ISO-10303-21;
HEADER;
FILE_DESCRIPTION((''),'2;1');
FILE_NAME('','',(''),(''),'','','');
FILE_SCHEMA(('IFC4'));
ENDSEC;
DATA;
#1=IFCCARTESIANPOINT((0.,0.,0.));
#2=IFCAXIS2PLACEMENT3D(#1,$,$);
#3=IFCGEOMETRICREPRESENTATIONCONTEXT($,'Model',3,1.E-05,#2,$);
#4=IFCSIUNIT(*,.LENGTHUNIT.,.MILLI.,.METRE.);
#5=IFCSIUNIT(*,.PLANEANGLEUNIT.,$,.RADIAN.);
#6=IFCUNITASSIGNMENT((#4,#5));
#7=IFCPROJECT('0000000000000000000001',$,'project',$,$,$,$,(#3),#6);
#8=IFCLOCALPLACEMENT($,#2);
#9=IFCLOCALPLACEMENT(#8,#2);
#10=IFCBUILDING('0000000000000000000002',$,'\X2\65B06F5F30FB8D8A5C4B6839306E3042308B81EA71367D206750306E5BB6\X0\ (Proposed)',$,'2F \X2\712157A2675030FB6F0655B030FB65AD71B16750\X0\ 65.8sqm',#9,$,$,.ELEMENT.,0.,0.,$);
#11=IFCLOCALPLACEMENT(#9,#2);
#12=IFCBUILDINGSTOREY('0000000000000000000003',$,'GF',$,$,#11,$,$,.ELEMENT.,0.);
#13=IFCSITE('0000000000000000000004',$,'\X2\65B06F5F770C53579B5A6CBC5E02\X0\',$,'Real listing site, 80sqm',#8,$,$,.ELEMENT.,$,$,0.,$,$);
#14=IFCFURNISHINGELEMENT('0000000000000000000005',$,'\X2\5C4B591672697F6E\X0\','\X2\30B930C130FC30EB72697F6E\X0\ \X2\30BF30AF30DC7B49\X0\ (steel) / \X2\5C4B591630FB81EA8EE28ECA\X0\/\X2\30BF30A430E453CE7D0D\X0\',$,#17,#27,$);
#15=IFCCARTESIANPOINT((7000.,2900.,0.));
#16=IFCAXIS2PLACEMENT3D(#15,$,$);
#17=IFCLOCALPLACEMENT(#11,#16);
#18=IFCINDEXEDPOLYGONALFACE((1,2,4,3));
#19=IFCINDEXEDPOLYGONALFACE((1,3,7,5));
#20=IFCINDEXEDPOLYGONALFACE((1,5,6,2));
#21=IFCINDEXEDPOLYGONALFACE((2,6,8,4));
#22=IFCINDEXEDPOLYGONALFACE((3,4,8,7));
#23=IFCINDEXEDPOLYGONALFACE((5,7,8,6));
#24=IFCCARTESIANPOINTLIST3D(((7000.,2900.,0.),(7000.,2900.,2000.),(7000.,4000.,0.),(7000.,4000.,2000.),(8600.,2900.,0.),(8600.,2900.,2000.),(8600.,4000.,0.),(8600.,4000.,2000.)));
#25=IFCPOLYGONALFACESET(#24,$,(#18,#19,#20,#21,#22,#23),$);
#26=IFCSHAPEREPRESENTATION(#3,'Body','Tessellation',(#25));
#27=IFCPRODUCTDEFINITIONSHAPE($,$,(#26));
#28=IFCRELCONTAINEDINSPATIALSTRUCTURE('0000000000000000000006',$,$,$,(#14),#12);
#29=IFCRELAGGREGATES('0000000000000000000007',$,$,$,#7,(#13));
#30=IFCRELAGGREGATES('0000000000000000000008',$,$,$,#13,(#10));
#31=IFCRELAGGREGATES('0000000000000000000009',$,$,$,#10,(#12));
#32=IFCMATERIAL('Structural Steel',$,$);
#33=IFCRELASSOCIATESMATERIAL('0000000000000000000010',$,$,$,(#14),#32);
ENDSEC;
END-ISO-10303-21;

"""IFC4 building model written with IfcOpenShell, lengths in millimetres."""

from ifc_helpers import new_model, si_unit, frame, frame_2d, origin, place, context, project, spatial, rectangle, extrude, material, element, save


model = new_model("IFC4")

# Units and contexts
model_context = context("Model", 3, precision=1e-05, world=origin())
ifc_project = project(units=[si_unit("LENGTHUNIT", "METRE", prefix="MILLI"), si_unit("PLANEANGLEUNIT", "RADIAN")], contexts=[model_context])

# Site, building, storey
site_placement = place(None, origin())
site = spatial("IfcSite", under=ifc_project, at=site_placement, Name="新潟県南魚沼市", ObjectType="Real listing site, 80sqm", CompositionType="ELEMENT", RefElevation=0.0)
building_placement = place(site_placement, origin())
building = spatial("IfcBuilding", under=site, at=building_placement, Name="新潟・越屋根のある自然素材の家 (Proposed)", ObjectType="2F 無垢材・漆喰・断熱材 65.8sqm", CompositionType="ELEMENT", ElevationOfRefHeight=0.0, ElevationOfTerrain=0.0)
storey_placement = place(building_placement, origin())
storey = spatial("IfcBuildingStorey", under=building, at=storey_placement, Name="GF", CompositionType="ELEMENT", Elevation=0.0)

# Shared definitions
ifc_material_1 = material(Name="Structural Steel")

# Furnishing element
furnishing_1_placement = place(storey_placement, frame((7000.0, 2900.0, 0.0)))
element("IfcFurnishingElement", 1, at=furnishing_1_placement, inside=storey, material=ifc_material_1, Name="屋外物置", Description="スチール物置 タクボ等 (steel) / 屋外・自転車/タイヤ収納", context=model_context, shape_type="SweptSolid", body=[
    extrude(rectangle(XDim=1600.0, YDim=1100.0, at=frame_2d((800.0, 550.0))), frame((7000.0, 2900.0, 0.0)), (0.0, 0.0, 1.0), 2000.0),
])

save(model, "model.ifc")
